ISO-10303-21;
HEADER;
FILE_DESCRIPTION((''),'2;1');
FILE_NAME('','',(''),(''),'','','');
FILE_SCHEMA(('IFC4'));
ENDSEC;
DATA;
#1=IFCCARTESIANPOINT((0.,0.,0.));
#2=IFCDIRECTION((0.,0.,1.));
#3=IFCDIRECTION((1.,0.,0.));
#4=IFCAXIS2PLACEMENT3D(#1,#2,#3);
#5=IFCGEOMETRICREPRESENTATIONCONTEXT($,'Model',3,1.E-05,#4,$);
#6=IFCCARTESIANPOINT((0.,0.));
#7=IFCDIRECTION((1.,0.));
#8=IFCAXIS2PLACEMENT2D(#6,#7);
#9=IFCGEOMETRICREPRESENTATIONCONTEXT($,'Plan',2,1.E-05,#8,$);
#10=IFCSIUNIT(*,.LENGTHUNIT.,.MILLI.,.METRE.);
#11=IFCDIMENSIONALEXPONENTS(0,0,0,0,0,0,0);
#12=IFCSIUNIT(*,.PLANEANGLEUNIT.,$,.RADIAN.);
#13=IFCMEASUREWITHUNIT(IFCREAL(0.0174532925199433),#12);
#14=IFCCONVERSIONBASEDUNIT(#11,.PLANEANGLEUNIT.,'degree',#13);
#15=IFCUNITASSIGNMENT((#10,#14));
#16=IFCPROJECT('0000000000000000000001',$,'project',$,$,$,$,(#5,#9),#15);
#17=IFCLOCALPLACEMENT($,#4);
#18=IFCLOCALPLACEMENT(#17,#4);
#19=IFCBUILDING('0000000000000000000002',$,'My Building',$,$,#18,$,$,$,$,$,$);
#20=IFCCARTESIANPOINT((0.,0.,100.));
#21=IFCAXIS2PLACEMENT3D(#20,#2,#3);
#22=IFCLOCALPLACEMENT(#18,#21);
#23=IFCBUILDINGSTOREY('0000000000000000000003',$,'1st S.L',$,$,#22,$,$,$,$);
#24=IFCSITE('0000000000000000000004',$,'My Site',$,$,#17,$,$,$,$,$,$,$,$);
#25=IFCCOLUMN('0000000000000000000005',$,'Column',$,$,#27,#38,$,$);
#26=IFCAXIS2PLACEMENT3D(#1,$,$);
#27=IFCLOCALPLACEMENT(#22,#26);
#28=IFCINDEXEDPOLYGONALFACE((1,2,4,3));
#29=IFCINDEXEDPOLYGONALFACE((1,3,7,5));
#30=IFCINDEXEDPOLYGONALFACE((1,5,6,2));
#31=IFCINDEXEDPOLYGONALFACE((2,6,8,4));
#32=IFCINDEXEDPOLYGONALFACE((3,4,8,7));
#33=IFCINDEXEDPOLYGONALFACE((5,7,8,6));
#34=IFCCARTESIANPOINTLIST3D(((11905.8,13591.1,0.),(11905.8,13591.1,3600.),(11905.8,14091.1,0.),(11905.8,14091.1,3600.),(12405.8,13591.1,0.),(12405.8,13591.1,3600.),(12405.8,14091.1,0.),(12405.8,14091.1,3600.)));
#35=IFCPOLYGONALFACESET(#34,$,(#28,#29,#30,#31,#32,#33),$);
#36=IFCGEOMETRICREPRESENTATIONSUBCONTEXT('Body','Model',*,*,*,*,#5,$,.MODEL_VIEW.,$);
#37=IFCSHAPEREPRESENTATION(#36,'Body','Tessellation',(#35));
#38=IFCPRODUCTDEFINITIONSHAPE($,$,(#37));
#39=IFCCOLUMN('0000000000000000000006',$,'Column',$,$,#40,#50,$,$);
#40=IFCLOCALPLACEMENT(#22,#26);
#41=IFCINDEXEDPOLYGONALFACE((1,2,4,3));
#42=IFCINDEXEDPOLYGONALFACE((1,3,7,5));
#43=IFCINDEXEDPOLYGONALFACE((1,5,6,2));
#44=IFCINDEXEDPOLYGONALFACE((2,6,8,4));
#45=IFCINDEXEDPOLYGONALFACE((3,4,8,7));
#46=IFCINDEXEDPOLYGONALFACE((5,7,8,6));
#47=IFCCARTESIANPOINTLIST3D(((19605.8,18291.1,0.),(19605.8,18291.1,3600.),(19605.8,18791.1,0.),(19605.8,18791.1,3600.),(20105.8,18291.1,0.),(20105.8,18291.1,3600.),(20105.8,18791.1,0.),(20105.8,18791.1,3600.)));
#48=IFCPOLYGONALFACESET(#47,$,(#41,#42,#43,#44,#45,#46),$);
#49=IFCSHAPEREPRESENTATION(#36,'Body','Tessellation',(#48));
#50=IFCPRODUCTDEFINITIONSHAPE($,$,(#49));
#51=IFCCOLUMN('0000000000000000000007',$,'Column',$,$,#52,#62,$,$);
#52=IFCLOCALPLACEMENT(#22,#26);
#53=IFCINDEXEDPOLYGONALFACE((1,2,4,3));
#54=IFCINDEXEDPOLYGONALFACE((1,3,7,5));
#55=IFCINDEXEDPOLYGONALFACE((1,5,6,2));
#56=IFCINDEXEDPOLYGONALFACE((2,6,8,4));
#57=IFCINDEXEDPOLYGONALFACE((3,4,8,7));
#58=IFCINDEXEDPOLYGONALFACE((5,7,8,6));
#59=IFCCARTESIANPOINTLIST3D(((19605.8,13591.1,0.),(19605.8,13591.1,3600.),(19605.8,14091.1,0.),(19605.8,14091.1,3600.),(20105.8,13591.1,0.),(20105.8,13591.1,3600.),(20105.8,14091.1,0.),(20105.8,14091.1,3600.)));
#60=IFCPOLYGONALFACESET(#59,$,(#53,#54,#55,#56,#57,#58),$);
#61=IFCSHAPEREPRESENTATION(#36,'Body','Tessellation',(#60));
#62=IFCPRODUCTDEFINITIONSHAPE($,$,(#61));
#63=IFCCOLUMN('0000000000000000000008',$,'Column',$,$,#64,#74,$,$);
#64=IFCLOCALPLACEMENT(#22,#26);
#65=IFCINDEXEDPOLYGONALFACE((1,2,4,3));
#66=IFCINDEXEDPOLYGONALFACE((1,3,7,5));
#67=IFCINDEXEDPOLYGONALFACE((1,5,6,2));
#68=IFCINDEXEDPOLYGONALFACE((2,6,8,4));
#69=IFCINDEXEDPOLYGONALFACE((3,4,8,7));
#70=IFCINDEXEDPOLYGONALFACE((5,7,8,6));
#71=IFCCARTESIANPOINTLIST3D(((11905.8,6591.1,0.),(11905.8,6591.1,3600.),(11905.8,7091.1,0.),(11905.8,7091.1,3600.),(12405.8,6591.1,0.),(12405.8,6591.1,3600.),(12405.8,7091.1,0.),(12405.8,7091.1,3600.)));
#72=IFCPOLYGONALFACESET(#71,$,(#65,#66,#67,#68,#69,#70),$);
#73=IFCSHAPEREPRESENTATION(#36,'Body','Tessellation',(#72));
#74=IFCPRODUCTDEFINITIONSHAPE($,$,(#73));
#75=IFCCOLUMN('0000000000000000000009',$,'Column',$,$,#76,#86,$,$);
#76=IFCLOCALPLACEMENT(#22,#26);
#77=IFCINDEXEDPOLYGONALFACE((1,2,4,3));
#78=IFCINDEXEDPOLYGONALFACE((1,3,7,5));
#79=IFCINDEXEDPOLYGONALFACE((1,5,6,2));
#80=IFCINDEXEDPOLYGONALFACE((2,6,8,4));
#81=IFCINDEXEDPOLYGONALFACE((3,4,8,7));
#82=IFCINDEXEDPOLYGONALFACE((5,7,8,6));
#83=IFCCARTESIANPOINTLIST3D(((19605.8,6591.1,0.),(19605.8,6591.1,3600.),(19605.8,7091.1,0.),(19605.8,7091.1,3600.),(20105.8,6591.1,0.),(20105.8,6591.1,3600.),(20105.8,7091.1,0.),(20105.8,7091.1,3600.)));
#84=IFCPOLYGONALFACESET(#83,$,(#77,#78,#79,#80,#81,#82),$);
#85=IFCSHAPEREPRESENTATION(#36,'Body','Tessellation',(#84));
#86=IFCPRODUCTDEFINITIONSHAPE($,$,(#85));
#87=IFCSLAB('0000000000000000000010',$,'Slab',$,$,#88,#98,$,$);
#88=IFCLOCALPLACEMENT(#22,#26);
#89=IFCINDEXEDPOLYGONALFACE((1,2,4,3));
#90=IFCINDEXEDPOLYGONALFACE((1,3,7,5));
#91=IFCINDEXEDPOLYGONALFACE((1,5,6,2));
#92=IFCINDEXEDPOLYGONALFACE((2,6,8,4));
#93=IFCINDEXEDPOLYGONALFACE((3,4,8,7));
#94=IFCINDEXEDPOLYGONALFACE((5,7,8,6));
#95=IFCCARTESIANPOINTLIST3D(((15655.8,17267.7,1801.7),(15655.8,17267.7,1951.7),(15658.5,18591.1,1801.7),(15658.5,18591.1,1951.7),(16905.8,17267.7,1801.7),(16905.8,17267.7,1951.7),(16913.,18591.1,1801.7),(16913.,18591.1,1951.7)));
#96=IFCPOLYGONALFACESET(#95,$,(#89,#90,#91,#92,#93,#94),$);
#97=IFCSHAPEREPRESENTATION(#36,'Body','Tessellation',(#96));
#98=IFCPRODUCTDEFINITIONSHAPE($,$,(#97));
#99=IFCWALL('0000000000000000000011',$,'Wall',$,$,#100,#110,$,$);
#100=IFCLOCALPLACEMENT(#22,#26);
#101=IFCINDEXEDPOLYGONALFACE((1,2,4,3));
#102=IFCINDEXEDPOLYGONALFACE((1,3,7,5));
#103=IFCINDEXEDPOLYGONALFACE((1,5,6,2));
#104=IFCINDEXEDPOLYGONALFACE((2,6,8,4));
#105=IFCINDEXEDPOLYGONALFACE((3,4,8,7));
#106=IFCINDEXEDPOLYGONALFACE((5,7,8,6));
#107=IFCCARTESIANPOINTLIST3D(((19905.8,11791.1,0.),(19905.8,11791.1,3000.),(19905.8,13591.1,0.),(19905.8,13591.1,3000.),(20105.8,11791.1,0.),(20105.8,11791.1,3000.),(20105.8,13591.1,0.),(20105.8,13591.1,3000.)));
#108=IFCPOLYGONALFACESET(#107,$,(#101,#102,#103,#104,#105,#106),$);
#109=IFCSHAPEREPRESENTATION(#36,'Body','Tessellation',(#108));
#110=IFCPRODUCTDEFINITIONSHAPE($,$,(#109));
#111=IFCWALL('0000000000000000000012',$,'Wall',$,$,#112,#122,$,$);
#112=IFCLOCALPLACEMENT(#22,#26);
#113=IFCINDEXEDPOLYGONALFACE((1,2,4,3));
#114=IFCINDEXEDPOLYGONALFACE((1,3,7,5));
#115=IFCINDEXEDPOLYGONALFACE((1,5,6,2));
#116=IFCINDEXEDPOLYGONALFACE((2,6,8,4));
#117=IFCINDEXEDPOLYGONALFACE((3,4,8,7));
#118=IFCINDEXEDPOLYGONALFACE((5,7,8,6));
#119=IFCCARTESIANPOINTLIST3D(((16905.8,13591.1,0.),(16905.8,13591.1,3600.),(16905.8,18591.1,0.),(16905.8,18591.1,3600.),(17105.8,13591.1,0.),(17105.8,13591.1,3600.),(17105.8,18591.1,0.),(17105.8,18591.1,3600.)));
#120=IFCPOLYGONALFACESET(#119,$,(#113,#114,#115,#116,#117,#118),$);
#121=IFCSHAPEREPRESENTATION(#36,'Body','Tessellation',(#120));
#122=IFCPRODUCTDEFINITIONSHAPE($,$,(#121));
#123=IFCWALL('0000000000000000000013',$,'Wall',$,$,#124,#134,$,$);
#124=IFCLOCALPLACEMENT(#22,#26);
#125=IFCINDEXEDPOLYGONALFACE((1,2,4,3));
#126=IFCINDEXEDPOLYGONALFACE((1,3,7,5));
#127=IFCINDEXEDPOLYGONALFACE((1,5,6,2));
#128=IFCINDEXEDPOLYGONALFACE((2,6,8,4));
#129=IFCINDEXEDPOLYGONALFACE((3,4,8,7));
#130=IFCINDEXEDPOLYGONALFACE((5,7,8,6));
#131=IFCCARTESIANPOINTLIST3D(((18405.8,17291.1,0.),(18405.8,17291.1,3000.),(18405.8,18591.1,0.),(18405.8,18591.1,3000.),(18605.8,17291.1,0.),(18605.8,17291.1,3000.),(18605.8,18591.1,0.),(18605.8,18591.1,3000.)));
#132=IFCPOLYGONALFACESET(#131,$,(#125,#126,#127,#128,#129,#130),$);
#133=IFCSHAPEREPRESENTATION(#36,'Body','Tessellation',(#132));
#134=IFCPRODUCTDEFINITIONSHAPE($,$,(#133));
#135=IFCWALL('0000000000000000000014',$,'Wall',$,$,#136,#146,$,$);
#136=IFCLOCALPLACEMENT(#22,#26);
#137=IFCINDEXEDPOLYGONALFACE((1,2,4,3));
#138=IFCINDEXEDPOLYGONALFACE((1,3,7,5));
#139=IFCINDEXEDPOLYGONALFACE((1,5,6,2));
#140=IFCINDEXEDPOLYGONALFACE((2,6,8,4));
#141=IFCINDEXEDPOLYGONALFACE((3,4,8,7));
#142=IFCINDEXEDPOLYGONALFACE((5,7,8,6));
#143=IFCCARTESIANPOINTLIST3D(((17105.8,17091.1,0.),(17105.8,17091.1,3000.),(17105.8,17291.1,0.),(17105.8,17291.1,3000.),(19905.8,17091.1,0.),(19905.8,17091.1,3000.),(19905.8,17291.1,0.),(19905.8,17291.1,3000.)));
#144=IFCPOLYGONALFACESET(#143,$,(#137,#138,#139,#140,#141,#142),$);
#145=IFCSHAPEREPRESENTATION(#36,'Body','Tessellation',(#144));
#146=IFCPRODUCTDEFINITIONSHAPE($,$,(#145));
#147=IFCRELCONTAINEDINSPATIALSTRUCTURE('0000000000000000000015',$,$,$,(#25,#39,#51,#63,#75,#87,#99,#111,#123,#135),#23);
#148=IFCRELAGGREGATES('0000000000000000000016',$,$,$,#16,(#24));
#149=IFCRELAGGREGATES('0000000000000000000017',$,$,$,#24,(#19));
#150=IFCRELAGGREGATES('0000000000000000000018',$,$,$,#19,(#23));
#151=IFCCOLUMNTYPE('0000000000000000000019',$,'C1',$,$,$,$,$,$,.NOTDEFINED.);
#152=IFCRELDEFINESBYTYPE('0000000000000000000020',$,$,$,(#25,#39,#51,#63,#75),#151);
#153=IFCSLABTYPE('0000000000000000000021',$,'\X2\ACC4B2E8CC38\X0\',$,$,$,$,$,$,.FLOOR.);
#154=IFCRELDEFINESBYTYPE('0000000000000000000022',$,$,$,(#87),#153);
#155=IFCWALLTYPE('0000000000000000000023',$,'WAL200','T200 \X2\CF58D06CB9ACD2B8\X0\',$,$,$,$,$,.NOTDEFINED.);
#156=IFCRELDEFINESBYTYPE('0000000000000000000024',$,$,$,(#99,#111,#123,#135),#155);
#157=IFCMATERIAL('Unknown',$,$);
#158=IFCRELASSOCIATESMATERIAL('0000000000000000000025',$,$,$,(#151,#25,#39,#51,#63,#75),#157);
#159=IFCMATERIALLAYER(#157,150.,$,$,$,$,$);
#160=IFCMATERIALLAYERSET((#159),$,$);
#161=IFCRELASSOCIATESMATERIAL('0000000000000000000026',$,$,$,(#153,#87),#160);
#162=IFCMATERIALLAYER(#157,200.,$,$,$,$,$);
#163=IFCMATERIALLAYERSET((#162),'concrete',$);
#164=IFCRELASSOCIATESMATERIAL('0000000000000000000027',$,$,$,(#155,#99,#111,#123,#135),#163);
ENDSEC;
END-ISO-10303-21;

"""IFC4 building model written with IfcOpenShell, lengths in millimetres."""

from ifc_helpers import new_model, entity, si_unit, converted_unit, frame, origin_with_axes, origin_2d_with_axis, place, context, subcontext, project, spatial, indexed_curve, rectangle, outline, extrude, material, layer, layer_set, layer_usage, material_profile, profile_set, profile_usage, type_object, element, save


model = new_model("IFC4")

# Units and contexts
model_context = context("Model", 3, precision=1e-05, world=origin_with_axes())
plan_context = context("Plan", 2, precision=1e-05, world=origin_2d_with_axis())
body_context_1 = subcontext(model_context, "Body", "Model", "MODEL_VIEW")
ifc_project = project(units=[si_unit("LENGTHUNIT", "METRE", prefix="MILLI"), converted_unit("PLANEANGLEUNIT", "degree", entity("IfcReal", 0.0174532925199433), si_unit("PLANEANGLEUNIT", "RADIAN"), dimensions=[0, 0, 0, 0, 0, 0, 0])], contexts=[model_context, plan_context])

# Site, building, storey
site_placement = place(None, origin_with_axes())
site = spatial("IfcSite", under=ifc_project, at=site_placement, Name="My Site")
building_placement = place(site_placement, origin_with_axes())
building = spatial("IfcBuilding", under=site, at=building_placement, Name="My Building")
storey_placement = place(building_placement, frame((0.0, 0.0, 100.0), z_axis=(0.0, 0.0, 1.0), x_axis=(1.0, 0.0, 0.0)))
storey = spatial("IfcBuildingStorey", under=building, at=storey_placement, Name="1st S.L")

# Shared definitions
ifc_material_1 = material(Name="Unknown")

# Columns
ifc_material_profile = material_profile(ifc_material_1, rectangle(XDim=500.0, YDim=500.0, kind="CURVE"))
ifc_profile_set = profile_set([ifc_material_profile], Name="concrete")
ifc_profile_usage_1 = profile_usage(ifc_profile_set, cardinal=5)
column_type = type_object("IfcColumnType", Name="C1", PredefinedType="NOTDEFINED", material=ifc_profile_set)
column_1_placement = place(storey_placement, frame((12155.8, 13841.1, 0.0), z_axis=(0.0, 0.0, 1.0), x_axis=(1.0, 0.0, 0.0)))
element("IfcColumn", 1, at=column_1_placement, inside=storey, type_object=column_type, material=ifc_profile_usage_1, Name="Column", context=body_context_1, shape_type="SweptSolid", body=[
    extrude(rectangle(XDim=500.0, YDim=500.0, kind="CURVE"), origin_with_axes(), (0.0, 0.0, 1.0), 3600.0),
])
ifc_profile_usage_2 = profile_usage(ifc_profile_set, cardinal=5)
column_2_placement = place(storey_placement, frame((19855.8, 18541.1, 0.0), z_axis=(0.0, 0.0, 1.0), x_axis=(1.0, 0.0, 0.0)))
element("IfcColumn", 2, at=column_2_placement, inside=storey, type_object=column_type, material=ifc_profile_usage_2, Name="Column", context=body_context_1, shape_type="SweptSolid", body=[
    extrude(rectangle(XDim=500.0, YDim=500.0, kind="CURVE"), origin_with_axes(), (0.0, 0.0, 1.0), 3600.0),
])
ifc_profile_usage_3 = profile_usage(ifc_profile_set, cardinal=5)
column_3_placement = place(storey_placement, frame((19855.8, 13841.1, 0.0), z_axis=(0.0, 0.0, 1.0), x_axis=(1.0, 0.0, 0.0)))
element("IfcColumn", 3, at=column_3_placement, inside=storey, type_object=column_type, material=ifc_profile_usage_3, Name="Column", context=body_context_1, shape_type="SweptSolid", body=[
    extrude(rectangle(XDim=500.0, YDim=500.0, kind="CURVE"), origin_with_axes(), (0.0, 0.0, 1.0), 3600.0),
])
ifc_profile_usage_4 = profile_usage(ifc_profile_set, cardinal=5)
column_4_placement = place(storey_placement, frame((12155.8, 6841.1, 0.0), z_axis=(0.0, 0.0, 1.0), x_axis=(1.0, 0.0, 0.0)))
element("IfcColumn", 4, at=column_4_placement, inside=storey, type_object=column_type, material=ifc_profile_usage_4, Name="Column", context=body_context_1, shape_type="SweptSolid", body=[
    extrude(rectangle(XDim=500.0, YDim=500.0, kind="CURVE"), origin_with_axes(), (0.0, 0.0, 1.0), 3600.0),
])
ifc_profile_usage_5 = profile_usage(ifc_profile_set, cardinal=5)
column_5_placement = place(storey_placement, frame((19855.8, 6841.1, 0.0), z_axis=(0.0, 0.0, 1.0), x_axis=(1.0, 0.0, 0.0)))
element("IfcColumn", 5, at=column_5_placement, inside=storey, type_object=column_type, material=ifc_profile_usage_5, Name="Column", context=body_context_1, shape_type="SweptSolid", body=[
    extrude(rectangle(XDim=500.0, YDim=500.0, kind="CURVE"), origin_with_axes(), (0.0, 0.0, 1.0), 3600.0),
])

# Slab
ifc_layer_1 = layer(ifc_material_1, 150.0)
ifc_layer_set_1 = layer_set([ifc_layer_1])
ifc_layer_usage_1 = layer_usage(ifc_layer_set_1, "AXIS3", "POSITIVE", -150.0)
slab_type = type_object("IfcSlabType", Name="계단참", PredefinedType="FLOOR", material=ifc_layer_set_1)
slab_placement = place(storey_placement, frame((15658.5, 18591.1, 1951.7), z_axis=(0.0, 0.0, 1.0), x_axis=(1.0, 0.0, 0.0)))
element("IfcSlab", 6, at=slab_placement, inside=storey, type_object=slab_type, material=ifc_layer_usage_1, Name="Slab", context=body_context_1, shape_type="SolidModel", body=[
    extrude(outline(indexed_curve([(0.0, 0.0), (1254.5, 0.0), (1247.4, -1323.4), (-2.6, -1323.4), (0.0, 0.0)])), frame((0.0, 0.0, -150.0), z_axis=(0.0, 0.0, 1.0), x_axis=(1.0, 0.0, 0.0)), (0.0, 0.0, 1.0), 150.0),
])

# Walls
ifc_layer_2 = layer(ifc_material_1, 200.0)
ifc_layer_set_2 = layer_set([ifc_layer_2], Name="concrete")
ifc_layer_usage_2 = layer_usage(ifc_layer_set_2, "AXIS2", "POSITIVE", 0.0)
wall_type = type_object("IfcWallType", Name="WAL200", Description="T200 콘크리트", PredefinedType="NOTDEFINED", material=ifc_layer_set_2)
wall_1_placement = place(storey_placement, frame((20105.8, 11791.1, 0.0), z_axis=(0.0, 0.0, 1.0), x_axis=(0.0, 1.0, 0.0)))
element("IfcWall", 7, at=wall_1_placement, inside=storey, type_object=wall_type, material=ifc_layer_usage_2, Name="Wall", context=body_context_1, shape_type="SweptSolid", body=[
    extrude(outline(indexed_curve([(0.0, 0.0), (0.0, 200.0), (1800.0, 200.0), (1800.0, 0.0), (0.0, 0.0)], self_intersect=False)), origin_with_axes(), (0.0, 0.0, 1.0), 3000.0),
])
ifc_layer_usage_3 = layer_usage(ifc_layer_set_2, "AXIS2", "POSITIVE", 0.0)
wall_2_placement = place(storey_placement, frame((17105.8, 13591.1, 0.0), z_axis=(0.0, 0.0, 1.0), x_axis=(0.0, 1.0, 0.0)))
element("IfcWall", 8, at=wall_2_placement, inside=storey, type_object=wall_type, material=ifc_layer_usage_3, Name="Wall", context=body_context_1, shape_type="SweptSolid", body=[
    extrude(outline(indexed_curve([(0.0, 0.0), (0.0, 200.0), (5000.0, 200.0), (5000.0, 0.0), (0.0, 0.0)], self_intersect=False)), origin_with_axes(), (0.0, 0.0, 1.0), 3600.0),
])
ifc_layer_usage_4 = layer_usage(ifc_layer_set_2, "AXIS2", "POSITIVE", 0.0)
wall_3_placement = place(storey_placement, frame((18605.8, 17291.1, 0.0), z_axis=(0.0, 0.0, 1.0), x_axis=(0.0, 1.0, 0.0)))
element("IfcWall", 9, at=wall_3_placement, inside=storey, type_object=wall_type, material=ifc_layer_usage_4, Name="Wall", context=body_context_1, shape_type="SweptSolid", body=[
    extrude(outline(indexed_curve([(0.0, 0.0), (0.0, 200.0), (1300.0, 200.0), (1300.0, 0.0), (0.0, 0.0)], self_intersect=False)), origin_with_axes(), (0.0, 0.0, 1.0), 3000.0),
])
ifc_layer_usage_5 = layer_usage(ifc_layer_set_2, "AXIS2", "POSITIVE", 0.0)
wall_4_placement = place(storey_placement, frame((17105.8, 17091.1, 0.0), z_axis=(0.0, 0.0, 1.0), x_axis=(1.0, 0.0, 0.0)))
element("IfcWall", 10, at=wall_4_placement, inside=storey, type_object=wall_type, material=ifc_layer_usage_5, Name="Wall", context=body_context_1, shape_type="SweptSolid", body=[
    extrude(outline(indexed_curve([(0.0, 0.0), (0.0, 200.0), (2800.0, 200.0), (2800.0, 0.0), (0.0, 0.0)], self_intersect=False)), origin_with_axes(), (0.0, 0.0, 1.0), 3000.0),
])

save(model, "model.ifc")
